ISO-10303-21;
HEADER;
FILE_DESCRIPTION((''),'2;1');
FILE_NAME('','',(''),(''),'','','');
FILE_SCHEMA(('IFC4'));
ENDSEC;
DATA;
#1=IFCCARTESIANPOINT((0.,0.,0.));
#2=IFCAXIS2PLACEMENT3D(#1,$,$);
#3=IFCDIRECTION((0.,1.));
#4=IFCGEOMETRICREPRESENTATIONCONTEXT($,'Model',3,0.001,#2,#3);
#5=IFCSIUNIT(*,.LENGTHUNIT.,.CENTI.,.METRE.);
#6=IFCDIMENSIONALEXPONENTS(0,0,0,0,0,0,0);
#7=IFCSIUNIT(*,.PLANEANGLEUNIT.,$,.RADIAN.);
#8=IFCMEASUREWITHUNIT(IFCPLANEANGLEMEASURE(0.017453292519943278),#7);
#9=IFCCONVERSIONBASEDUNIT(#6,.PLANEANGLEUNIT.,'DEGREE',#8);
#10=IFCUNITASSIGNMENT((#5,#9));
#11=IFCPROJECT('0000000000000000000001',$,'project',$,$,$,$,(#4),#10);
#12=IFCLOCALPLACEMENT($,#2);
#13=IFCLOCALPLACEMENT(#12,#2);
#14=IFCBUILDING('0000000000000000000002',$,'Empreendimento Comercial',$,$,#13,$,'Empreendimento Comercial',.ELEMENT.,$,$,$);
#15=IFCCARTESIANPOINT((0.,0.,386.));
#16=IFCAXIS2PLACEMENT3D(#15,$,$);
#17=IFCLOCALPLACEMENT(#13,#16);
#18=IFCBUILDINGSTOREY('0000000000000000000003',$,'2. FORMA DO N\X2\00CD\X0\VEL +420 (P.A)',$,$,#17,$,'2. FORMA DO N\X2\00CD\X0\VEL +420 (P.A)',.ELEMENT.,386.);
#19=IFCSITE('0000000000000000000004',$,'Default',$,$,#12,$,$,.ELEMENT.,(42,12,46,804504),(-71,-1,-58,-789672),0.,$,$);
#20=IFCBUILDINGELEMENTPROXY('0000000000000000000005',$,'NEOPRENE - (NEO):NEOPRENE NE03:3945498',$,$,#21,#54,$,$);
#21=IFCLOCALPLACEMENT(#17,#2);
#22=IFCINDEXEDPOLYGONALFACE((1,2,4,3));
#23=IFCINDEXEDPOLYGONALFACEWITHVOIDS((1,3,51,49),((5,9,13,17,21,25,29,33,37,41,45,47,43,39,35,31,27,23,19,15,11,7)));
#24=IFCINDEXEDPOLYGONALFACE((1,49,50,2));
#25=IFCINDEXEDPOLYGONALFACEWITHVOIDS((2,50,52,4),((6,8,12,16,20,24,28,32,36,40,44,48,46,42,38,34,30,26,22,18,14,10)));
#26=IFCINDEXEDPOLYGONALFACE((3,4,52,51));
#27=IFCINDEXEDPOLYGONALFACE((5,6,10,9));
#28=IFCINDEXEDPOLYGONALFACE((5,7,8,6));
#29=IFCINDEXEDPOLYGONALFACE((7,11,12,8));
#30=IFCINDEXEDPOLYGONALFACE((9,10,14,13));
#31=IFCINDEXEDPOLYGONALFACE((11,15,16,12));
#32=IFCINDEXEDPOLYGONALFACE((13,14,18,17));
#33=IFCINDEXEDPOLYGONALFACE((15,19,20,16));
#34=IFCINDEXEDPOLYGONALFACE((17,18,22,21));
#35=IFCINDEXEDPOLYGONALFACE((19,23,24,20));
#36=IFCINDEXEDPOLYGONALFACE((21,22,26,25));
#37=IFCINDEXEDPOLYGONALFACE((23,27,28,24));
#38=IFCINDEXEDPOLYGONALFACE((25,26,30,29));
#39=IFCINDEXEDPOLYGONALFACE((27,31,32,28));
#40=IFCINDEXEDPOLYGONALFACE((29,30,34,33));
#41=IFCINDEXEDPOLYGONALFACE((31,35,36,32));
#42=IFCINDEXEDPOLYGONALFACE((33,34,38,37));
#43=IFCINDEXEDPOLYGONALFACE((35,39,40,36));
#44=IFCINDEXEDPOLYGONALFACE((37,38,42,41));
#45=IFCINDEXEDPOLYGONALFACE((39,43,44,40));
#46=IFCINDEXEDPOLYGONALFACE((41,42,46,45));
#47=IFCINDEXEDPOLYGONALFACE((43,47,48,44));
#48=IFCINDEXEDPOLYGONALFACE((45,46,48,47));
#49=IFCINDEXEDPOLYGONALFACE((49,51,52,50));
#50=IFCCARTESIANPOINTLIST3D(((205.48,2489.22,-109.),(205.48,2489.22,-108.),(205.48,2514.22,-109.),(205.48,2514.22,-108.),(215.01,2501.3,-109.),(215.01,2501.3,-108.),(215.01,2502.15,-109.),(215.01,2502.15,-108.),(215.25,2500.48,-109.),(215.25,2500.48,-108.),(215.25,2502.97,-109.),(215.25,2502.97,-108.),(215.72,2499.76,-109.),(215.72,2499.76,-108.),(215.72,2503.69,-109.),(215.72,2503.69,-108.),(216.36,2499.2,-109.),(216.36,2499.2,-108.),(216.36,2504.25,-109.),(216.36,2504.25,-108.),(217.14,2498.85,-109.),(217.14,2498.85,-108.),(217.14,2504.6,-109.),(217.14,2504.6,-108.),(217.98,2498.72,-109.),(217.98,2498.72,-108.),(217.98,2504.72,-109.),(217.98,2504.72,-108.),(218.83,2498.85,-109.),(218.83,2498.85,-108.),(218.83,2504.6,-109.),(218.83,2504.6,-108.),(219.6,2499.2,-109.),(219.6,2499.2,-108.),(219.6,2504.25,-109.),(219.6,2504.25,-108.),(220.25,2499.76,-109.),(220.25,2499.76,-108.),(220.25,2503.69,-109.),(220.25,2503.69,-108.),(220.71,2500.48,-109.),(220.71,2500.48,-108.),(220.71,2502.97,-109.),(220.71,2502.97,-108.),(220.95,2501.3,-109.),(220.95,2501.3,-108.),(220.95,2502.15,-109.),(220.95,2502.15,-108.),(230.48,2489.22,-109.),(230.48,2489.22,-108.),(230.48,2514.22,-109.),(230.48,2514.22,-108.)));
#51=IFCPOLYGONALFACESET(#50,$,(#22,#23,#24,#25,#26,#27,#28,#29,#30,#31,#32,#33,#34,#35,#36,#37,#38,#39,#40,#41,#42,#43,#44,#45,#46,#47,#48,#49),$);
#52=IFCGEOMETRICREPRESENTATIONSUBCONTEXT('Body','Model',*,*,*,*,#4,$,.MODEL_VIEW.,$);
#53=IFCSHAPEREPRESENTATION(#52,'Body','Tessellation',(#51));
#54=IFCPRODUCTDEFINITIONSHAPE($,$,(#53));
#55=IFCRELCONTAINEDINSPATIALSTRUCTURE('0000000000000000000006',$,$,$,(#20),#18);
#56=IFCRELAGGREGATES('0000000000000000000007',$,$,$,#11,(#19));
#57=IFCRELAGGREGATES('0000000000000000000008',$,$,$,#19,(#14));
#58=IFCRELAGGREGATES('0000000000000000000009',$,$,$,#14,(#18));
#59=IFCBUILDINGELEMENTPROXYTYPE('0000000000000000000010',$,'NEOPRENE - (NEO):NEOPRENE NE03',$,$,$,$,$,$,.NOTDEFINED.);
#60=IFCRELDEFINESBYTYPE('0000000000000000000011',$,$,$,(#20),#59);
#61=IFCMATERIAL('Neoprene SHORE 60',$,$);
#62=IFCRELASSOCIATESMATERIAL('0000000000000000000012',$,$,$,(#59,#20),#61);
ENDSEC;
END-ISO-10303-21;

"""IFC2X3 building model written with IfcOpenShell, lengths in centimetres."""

from ifc_helpers import new_model, entity, si_unit, converted_unit, direction, frame, frame_2d, origin, place, context, subcontext, project, spatial, polyline, circle_curve, parameter, trimmed, segment, composite_curve, outline, extrude, source, transform, mapped, material, type_object, type_shapes, element, save


model = new_model("IFC2X3")

# Units and contexts
model_context = context("Model", 3, precision=0.001, world=origin(), true_north=direction((0.0, 1.0)))
body_context = subcontext(model_context, "Body", "Model", "MODEL_VIEW")
ifc_project = project(units=[si_unit("LENGTHUNIT", "METRE", prefix="CENTI"), converted_unit("PLANEANGLEUNIT", "DEGREE", entity("IfcPlaneAngleMeasure", 0.017453292519943278), si_unit("PLANEANGLEUNIT", "RADIAN"), dimensions=[0, 0, 0, 0, 0, 0, 0])], contexts=[model_context])

# Site, building, storey
site_placement = place(None, origin())
site = spatial("IfcSite", under=ifc_project, at=site_placement, Name="Default", CompositionType="ELEMENT", RefLatitude=(42, 12, 46, 804504), RefLongitude=(-71, -1, -58, -789672), RefElevation=0.0)
building_placement = place(site_placement, origin())
building = spatial("IfcBuilding", under=site, at=building_placement, Name="Empreendimento Comercial", LongName="Empreendimento Comercial", CompositionType="ELEMENT")
storey_placement = place(building_placement, frame((0.0, 0.0, 386.0)))
storey = spatial("IfcBuildingStorey", under=building, at=storey_placement, Name="2. FORMA DO NÍVEL +420 (P.A)", LongName="2. FORMA DO NÍVEL +420 (P.A)", CompositionType="ELEMENT", Elevation=386.0)

# Building element proxy
ifc_material_1 = material(Name="Neoprene SHORE 60")
building_element_proxy_type_1 = type_object("IfcBuildingElementProxyType", Name="NEOPRENE - (NEO):NEOPRENE NE03", PredefinedType="NOTDEFINED", material=ifc_material_1)
shared_shape_1 = source(origin(), body_context, "Body", "SweptSolid", [
    extrude(outline(polyline([(-12.5, -12.5), (12.5, -12.5), (12.5, 12.5), (-12.5, 12.5), (-12.5, -12.5)]), holes=[composite_curve([segment(trimmed(circle_curve(frame_2d((0.0, 0.0), x_axis=(-1.0, 0.0)), 3.0), [parameter(0.0)], [parameter(180.0)], True, "PARAMETER"), False, "CONTINUOUS"), segment(trimmed(circle_curve(frame_2d((0.0, 0.0), x_axis=(-1.0, 0.0)), 3.0), [parameter(180.0)], [parameter(0.0)], True, "PARAMETER"), False, "CONTINUOUS")], self_intersect=False)]), frame((0.0, 0.0, -71.0), z_axis=(0.0, 0.0, 1.0), x_axis=(-1.0, 0.0, 0.0)), (0.0, 0.0, 1.0), 1.0),
])
type_shapes(building_element_proxy_type_1, [shared_shape_1])
proxy_1_placement = place(storey_placement, frame((217.98, 2501.72, -38.0), z_axis=(0.0, 0.0, 1.0), x_axis=(0.0, -1.0, 0.0)))
element("IfcBuildingElementProxy", 1, at=proxy_1_placement, inside=storey, type_object=building_element_proxy_type_1, material=ifc_material_1, Name="NEOPRENE - (NEO):NEOPRENE NE03:3945498", context=body_context, shape_type="MappedRepresentation", body=[
    mapped(shared_shape_1, transform((0.0, 0.0, 0.0), scale=1.0)),
])

save(model, "model.ifc")
